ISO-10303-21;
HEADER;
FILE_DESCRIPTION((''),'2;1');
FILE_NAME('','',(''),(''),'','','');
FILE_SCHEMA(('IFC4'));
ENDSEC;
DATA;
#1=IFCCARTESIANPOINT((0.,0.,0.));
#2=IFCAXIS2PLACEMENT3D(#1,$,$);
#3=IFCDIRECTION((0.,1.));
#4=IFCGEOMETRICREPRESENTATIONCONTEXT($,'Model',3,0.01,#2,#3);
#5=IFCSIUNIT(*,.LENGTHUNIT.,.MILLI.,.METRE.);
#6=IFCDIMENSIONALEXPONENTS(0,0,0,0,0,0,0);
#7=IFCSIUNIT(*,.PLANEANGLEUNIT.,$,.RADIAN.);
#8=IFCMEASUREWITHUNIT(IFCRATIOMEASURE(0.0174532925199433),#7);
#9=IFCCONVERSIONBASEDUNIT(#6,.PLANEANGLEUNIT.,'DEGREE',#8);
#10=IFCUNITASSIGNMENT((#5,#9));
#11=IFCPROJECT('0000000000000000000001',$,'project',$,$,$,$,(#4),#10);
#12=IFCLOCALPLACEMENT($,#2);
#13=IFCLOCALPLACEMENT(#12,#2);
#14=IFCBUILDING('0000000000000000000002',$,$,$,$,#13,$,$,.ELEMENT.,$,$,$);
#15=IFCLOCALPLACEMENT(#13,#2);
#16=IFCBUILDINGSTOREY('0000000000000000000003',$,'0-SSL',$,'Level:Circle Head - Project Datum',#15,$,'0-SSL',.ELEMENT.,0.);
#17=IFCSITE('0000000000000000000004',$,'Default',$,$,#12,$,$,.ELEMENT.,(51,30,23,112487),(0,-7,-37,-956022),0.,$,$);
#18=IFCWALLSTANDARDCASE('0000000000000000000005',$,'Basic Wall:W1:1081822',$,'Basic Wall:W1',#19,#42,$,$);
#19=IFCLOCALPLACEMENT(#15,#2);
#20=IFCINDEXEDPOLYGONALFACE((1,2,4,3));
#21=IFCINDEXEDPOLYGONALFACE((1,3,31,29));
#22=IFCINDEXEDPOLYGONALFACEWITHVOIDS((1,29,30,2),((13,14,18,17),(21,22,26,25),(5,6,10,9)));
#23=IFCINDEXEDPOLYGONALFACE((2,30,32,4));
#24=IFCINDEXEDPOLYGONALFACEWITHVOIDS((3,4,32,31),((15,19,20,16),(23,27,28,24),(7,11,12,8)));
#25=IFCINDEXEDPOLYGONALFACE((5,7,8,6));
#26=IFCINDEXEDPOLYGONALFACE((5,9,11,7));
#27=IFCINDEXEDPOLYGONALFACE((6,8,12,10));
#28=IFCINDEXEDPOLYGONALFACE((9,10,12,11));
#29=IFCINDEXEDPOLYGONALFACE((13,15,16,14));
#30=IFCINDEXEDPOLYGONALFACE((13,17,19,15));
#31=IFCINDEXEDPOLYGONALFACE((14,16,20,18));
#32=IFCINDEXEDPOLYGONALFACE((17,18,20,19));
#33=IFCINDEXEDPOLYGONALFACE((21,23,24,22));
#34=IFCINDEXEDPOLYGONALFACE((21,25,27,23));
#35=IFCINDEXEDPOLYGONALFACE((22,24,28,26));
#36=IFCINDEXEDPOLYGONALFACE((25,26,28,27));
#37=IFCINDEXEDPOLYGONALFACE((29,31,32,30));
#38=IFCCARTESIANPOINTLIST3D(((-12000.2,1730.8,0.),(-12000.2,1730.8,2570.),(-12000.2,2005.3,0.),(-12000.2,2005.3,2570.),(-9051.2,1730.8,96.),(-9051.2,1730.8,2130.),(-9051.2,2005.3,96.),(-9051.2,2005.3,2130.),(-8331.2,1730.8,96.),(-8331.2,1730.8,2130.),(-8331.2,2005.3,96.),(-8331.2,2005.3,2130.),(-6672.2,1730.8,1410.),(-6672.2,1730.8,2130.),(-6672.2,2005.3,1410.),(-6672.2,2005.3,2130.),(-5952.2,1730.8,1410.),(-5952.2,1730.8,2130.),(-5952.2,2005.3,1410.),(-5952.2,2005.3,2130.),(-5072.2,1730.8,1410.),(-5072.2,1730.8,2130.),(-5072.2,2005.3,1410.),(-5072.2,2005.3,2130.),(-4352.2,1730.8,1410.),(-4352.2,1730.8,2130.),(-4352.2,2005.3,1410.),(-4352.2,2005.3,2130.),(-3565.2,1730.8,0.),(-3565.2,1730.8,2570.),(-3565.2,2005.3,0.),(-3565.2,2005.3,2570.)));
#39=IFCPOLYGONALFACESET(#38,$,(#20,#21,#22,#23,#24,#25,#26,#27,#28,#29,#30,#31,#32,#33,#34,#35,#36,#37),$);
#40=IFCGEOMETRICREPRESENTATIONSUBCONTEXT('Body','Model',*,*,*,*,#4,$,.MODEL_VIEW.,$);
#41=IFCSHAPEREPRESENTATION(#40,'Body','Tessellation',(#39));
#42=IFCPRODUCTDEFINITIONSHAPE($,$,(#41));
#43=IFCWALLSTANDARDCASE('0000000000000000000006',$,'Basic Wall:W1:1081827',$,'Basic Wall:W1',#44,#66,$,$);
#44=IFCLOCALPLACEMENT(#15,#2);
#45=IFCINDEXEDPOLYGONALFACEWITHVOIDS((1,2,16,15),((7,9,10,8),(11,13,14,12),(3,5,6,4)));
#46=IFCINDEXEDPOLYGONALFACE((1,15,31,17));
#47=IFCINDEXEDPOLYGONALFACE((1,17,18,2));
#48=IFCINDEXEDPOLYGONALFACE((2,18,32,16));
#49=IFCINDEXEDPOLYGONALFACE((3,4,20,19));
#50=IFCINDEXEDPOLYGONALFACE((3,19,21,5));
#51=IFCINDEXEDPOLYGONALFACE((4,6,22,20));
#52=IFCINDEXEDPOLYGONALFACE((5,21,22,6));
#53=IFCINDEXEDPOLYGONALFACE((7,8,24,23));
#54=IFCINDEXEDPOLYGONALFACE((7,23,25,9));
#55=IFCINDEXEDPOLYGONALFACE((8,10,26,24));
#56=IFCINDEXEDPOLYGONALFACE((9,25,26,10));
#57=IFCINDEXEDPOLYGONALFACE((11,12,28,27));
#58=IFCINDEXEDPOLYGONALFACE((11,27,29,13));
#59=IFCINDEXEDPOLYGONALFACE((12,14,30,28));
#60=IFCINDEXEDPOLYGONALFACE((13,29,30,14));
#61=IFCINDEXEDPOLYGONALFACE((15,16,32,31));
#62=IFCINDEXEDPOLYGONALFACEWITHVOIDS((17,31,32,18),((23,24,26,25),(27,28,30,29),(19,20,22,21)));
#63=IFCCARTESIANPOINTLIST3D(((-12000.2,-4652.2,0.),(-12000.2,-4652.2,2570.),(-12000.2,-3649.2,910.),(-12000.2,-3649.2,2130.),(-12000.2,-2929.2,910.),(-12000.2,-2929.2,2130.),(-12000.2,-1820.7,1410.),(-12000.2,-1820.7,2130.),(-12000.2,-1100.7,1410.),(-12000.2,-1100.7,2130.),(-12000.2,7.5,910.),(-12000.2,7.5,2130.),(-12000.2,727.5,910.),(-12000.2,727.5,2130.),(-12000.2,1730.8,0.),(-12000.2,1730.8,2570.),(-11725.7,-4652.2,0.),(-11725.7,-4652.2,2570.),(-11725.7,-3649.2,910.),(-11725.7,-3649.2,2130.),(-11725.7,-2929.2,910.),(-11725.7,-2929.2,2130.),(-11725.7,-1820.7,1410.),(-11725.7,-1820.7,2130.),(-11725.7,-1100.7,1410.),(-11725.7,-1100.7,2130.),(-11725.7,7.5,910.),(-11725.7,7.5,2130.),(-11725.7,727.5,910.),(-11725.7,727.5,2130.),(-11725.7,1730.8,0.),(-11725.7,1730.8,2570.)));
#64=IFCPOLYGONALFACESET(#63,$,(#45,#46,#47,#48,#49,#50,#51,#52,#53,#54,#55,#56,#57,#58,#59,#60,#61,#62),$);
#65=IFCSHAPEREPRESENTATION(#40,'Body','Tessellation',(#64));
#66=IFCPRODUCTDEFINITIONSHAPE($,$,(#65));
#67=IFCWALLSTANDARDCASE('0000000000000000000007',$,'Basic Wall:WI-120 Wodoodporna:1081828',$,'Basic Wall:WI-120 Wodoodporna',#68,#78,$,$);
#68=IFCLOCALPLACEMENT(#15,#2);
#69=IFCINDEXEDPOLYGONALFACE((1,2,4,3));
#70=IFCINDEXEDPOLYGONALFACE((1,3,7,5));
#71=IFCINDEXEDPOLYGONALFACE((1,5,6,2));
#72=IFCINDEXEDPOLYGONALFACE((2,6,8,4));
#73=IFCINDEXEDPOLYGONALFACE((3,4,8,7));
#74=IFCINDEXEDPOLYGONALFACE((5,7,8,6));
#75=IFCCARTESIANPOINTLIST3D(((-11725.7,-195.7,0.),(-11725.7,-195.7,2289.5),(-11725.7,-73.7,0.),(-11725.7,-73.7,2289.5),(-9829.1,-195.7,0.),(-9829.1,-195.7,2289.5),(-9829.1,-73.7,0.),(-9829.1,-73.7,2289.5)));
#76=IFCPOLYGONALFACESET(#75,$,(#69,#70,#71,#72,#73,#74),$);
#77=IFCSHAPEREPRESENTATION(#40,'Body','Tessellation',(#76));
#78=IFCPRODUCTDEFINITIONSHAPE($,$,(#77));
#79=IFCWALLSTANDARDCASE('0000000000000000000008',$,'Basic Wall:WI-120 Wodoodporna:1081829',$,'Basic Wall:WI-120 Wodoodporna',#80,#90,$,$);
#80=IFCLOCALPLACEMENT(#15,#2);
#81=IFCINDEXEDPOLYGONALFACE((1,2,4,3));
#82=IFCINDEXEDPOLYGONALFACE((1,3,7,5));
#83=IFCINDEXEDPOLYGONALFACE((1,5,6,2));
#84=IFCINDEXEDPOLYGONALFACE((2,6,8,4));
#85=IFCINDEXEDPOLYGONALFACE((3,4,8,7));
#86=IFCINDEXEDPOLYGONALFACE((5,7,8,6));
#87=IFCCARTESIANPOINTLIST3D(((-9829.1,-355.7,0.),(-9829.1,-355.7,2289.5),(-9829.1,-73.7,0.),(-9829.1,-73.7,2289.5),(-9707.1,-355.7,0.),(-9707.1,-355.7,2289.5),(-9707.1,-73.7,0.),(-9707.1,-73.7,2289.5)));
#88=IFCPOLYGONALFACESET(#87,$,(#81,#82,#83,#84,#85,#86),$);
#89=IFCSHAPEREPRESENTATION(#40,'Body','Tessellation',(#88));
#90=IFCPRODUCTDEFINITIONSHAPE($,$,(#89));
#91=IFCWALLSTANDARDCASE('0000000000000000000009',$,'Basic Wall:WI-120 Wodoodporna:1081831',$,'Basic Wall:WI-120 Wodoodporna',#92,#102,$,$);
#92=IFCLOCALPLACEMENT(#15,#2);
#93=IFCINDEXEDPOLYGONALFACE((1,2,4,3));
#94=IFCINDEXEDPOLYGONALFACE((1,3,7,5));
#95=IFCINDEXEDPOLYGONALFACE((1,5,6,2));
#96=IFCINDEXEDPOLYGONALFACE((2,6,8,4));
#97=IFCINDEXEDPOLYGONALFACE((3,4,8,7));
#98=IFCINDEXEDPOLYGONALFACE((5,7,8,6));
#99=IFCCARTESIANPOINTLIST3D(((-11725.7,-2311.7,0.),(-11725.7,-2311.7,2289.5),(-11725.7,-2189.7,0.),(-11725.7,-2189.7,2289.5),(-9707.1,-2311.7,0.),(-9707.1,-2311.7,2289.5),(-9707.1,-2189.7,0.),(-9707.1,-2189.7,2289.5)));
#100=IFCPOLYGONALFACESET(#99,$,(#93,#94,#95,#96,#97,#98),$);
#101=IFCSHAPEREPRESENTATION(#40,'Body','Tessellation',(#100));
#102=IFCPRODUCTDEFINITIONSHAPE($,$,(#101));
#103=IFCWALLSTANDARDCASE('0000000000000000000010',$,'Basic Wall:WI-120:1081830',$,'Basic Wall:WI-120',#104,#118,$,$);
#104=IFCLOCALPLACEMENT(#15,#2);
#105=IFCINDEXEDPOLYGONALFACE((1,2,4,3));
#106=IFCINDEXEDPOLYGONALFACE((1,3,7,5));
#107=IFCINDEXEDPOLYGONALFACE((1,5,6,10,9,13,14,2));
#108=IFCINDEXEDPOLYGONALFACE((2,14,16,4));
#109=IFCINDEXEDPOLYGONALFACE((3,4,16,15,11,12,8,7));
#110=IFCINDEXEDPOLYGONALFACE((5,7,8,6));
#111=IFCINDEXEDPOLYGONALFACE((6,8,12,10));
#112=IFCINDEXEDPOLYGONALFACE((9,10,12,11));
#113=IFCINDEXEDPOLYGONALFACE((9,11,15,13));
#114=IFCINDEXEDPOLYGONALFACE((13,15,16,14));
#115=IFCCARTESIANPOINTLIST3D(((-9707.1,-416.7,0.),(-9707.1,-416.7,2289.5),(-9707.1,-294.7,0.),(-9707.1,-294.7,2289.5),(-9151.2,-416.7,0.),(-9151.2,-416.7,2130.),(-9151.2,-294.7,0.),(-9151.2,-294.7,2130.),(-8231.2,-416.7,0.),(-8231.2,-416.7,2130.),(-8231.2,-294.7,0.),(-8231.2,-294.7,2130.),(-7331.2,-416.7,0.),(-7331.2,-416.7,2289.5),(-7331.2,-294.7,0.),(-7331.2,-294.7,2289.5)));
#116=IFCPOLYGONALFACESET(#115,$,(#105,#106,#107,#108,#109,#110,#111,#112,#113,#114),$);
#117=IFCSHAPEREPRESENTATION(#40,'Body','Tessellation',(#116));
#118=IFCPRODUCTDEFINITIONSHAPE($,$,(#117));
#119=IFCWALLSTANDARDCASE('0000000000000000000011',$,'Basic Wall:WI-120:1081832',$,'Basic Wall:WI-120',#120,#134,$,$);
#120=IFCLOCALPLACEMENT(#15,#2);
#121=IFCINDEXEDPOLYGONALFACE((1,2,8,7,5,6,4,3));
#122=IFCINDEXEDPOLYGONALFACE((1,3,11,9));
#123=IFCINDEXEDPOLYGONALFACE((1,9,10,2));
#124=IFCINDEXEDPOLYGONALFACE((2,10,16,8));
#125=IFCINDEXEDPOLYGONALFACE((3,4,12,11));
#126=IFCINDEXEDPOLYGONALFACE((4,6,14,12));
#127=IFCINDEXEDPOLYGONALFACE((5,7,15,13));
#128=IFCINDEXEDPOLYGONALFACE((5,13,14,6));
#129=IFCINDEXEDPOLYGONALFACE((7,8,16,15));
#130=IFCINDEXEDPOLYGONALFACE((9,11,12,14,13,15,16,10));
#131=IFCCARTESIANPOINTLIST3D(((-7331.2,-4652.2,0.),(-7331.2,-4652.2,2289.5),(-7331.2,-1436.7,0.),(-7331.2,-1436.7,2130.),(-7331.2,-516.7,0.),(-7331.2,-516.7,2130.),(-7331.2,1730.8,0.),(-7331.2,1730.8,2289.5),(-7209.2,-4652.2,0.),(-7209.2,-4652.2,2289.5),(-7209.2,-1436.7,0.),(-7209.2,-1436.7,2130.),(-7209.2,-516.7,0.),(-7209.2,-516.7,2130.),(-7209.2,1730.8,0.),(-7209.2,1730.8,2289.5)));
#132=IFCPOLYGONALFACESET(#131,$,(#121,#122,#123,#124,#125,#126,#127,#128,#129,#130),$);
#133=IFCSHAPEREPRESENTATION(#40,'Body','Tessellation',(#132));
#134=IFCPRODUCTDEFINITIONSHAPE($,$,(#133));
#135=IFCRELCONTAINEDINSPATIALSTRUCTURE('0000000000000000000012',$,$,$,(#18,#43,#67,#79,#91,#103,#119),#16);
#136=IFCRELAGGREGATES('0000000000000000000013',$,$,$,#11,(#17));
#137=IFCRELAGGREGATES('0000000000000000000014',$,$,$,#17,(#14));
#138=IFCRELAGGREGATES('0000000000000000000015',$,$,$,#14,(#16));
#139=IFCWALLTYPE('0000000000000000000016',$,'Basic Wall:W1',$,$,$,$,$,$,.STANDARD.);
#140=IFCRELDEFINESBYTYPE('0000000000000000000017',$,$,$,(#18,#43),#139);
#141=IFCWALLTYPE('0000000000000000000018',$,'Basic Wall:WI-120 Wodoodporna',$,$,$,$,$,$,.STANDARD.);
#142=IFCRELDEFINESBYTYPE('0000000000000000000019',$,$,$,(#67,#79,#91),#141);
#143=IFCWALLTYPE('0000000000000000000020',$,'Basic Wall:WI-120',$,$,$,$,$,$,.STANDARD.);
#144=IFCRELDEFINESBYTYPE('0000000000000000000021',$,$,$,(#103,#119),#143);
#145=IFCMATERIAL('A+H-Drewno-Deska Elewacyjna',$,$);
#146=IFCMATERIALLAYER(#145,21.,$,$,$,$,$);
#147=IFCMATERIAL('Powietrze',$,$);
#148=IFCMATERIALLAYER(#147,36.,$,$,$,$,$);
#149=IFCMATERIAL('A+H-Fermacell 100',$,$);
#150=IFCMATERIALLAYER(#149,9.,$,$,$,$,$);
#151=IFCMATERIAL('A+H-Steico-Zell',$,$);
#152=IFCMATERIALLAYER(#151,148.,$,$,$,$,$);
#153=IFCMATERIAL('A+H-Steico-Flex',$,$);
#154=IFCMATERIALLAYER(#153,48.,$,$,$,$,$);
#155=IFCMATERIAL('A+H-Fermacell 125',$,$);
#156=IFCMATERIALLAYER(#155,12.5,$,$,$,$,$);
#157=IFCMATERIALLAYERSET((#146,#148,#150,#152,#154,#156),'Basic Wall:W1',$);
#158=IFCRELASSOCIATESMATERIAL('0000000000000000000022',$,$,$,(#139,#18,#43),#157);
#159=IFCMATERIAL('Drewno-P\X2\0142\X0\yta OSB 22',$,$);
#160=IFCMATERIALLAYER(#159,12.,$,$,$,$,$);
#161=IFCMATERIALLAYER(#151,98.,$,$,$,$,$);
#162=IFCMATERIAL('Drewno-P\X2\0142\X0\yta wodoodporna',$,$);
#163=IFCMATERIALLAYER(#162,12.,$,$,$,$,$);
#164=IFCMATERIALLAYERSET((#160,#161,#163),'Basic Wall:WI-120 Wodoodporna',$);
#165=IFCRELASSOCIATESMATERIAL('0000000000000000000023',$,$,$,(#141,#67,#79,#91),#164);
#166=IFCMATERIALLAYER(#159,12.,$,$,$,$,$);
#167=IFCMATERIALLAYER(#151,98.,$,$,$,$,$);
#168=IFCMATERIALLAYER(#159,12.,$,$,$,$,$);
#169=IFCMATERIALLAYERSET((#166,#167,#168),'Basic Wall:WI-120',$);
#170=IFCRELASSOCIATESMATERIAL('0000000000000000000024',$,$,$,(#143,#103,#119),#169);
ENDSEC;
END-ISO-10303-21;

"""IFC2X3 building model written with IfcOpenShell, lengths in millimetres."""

from ifc_helpers import new_model, entity, si_unit, converted_unit, direction, frame, frame_2d, origin, place, context, subcontext, project, spatial, polyline, rectangle, extrude, clip, bounded_halfspace, material, layer, layer_set, layer_usage, type_object, element, save


model = new_model("IFC2X3")

# Units and contexts
model_context = context("Model", 3, precision=0.01, world=origin(), true_north=direction((0.0, 1.0)))
body_context = subcontext(model_context, "Body", "Model", "MODEL_VIEW")
ifc_project = project(units=[si_unit("LENGTHUNIT", "METRE", prefix="MILLI"), converted_unit("PLANEANGLEUNIT", "DEGREE", entity("IfcRatioMeasure", 0.0174532925199433), si_unit("PLANEANGLEUNIT", "RADIAN"), dimensions=[0, 0, 0, 0, 0, 0, 0])], contexts=[model_context])

# Site, building, storey
site_placement = place(None, origin())
site = spatial("IfcSite", under=ifc_project, at=site_placement, Name="Default", CompositionType="ELEMENT", RefLatitude=(51, 30, 23, 112487), RefLongitude=(0, -7, -37, -956022), RefElevation=0.0)
building_placement = place(site_placement, origin())
building = spatial("IfcBuilding", under=site, at=building_placement, CompositionType="ELEMENT")
storey_placement = place(building_placement, origin())
storey = spatial("IfcBuildingStorey", under=building, at=storey_placement, Name="0-SSL", ObjectType="Level:Circle Head - Project Datum", LongName="0-SSL", CompositionType="ELEMENT", Elevation=0.0)

# Walls, openings
ifc_material_1 = material(Name="A+H-Drewno-Deska Elewacyjna")
ifc_layer_1 = layer(ifc_material_1, 21.0)
ifc_material_2 = material(Name="Powietrze")
ifc_layer_2 = layer(ifc_material_2, 36.0)
ifc_material_3 = material(Name="A+H-Fermacell 100")
ifc_layer_3 = layer(ifc_material_3, 9.0)
ifc_material_4 = material(Name="A+H-Steico-Zell")
ifc_layer_4 = layer(ifc_material_4, 148.0)
ifc_material_5 = material(Name="A+H-Steico-Flex")
ifc_layer_5 = layer(ifc_material_5, 48.0)
ifc_material_6 = material(Name="A+H-Fermacell 125")
ifc_layer_6 = layer(ifc_material_6, 12.5)
ifc_layer_set_1 = layer_set([ifc_layer_1, ifc_layer_2, ifc_layer_3, ifc_layer_4, ifc_layer_5, ifc_layer_6], Name="Basic Wall:W1")
ifc_layer_usage_1 = layer_usage(ifc_layer_set_1, "AXIS2", "NEGATIVE", 137.2)
wall_type_1 = type_object("IfcWallType", Name="Basic Wall:W1", PredefinedType="STANDARD", material=ifc_layer_set_1)
wall_1_placement = place(storey_placement, frame((-12000.2, 1868.0, 0.0)))
wall_1 = element("IfcWallStandardCase", 1, at=wall_1_placement, inside=storey, type_object=wall_type_1, material=ifc_layer_usage_1, Name="Basic Wall:W1:1081822", ObjectType="Basic Wall:W1", context=body_context, shape_type="SweptSolid", body=[
    extrude(rectangle(XDim=8435.0, YDim=274.5, at=frame_2d((4217.5, 0.0), x_axis=(-1.0, 0.0))), origin(), (0.0, 0.0, 1.0), 2570.0),
])
opening_1_placement = place(wall_1_placement, frame((2949.0, -137.2, 96.0)))
element("IfcOpeningElement", 2, at=opening_1_placement, cuts=wall_1, ObjectType="Opening", context=body_context, shape_type="SweptSolid", body=[
    extrude(rectangle(XDim=2034.0, YDim=720.0, at=frame_2d((1017.0, 360.0), x_axis=(-1.0, 0.0))), frame((0.0, 0.0, 0.0), z_axis=(0.0, 1.0, 0.0), x_axis=(0.0, 0.0, 1.0)), (0.0, 0.0, 1.0), 274.5),
])
opening_2_placement = place(wall_1_placement, frame((5328.0, -137.2, 1410.0)))
element("IfcOpeningElement", 3, at=opening_2_placement, cuts=wall_1, ObjectType="Opening", context=body_context, shape_type="SweptSolid", body=[
    extrude(rectangle(XDim=720.0, YDim=720.0, at=frame_2d((360.0, 360.0), x_axis=(-1.0, 0.0))), frame((0.0, 0.0, 0.0), z_axis=(0.0, 1.0, 0.0), x_axis=(0.0, 0.0, 1.0)), (0.0, 0.0, 1.0), 274.5),
])
opening_3_placement = place(wall_1_placement, frame((6928.0, -137.2, 1410.0)))
element("IfcOpeningElement", 4, at=opening_3_placement, cuts=wall_1, ObjectType="Opening", context=body_context, shape_type="SweptSolid", body=[
    extrude(rectangle(XDim=720.0, YDim=720.0, at=frame_2d((360.0, 360.0), x_axis=(-1.0, 0.0))), frame((0.0, 0.0, 0.0), z_axis=(0.0, 1.0, 0.0), x_axis=(0.0, 0.0, 1.0)), (0.0, 0.0, 1.0), 274.5),
])
ifc_layer_usage_2 = layer_usage(ifc_layer_set_1, "AXIS2", "NEGATIVE", 137.2)
wall_2_placement = place(storey_placement, frame((-11862.9, -4652.2, 0.0), z_axis=(0.0, 0.0, 1.0), x_axis=(0.0, 1.0, 0.0)))
wall_2 = element("IfcWallStandardCase", 5, at=wall_2_placement, inside=storey, type_object=wall_type_1, material=ifc_layer_usage_2, Name="Basic Wall:W1:1081827", ObjectType="Basic Wall:W1", context=body_context, shape_type="SweptSolid", body=[
    extrude(rectangle(XDim=6383.0, YDim=274.5, at=frame_2d((3191.5, 0.0), x_axis=(-1.0, 0.0))), origin(), (0.0, 0.0, 1.0), 2570.0),
])
opening_4_placement = place(wall_2_placement, frame((4659.7, -137.3, 910.0)))
element("IfcOpeningElement", 6, at=opening_4_placement, cuts=wall_2, ObjectType="Opening", context=body_context, shape_type="SweptSolid", body=[
    extrude(rectangle(XDim=1220.0, YDim=720.0, at=frame_2d((610.0, 360.0), x_axis=(-1.0, 0.0))), frame((0.0, 0.0, 0.0), z_axis=(0.0, 1.0, 0.0), x_axis=(0.0, 0.0, 1.0)), (0.0, 0.0, 1.0), 274.5),
])
opening_5_placement = place(wall_2_placement, frame((1003.0, -137.3, 910.0)))
element("IfcOpeningElement", 7, at=opening_5_placement, cuts=wall_2, ObjectType="Opening", context=body_context, shape_type="SweptSolid", body=[
    extrude(rectangle(XDim=1220.0, YDim=720.0, at=frame_2d((610.0, 360.0), x_axis=(-1.0, 0.0))), frame((0.0, 0.0, 0.0), z_axis=(0.0, 1.0, 0.0), x_axis=(0.0, 0.0, 1.0)), (0.0, 0.0, 1.0), 274.5),
])
opening_6_placement = place(wall_2_placement, frame((2831.5, -137.3, 1410.0)))
element("IfcOpeningElement", 8, at=opening_6_placement, cuts=wall_2, ObjectType="Opening", context=body_context, shape_type="SweptSolid", body=[
    extrude(rectangle(XDim=720.0, YDim=720.0, at=frame_2d((360.0, 360.0), x_axis=(-1.0, 0.0))), frame((0.0, 0.0, 0.0), z_axis=(0.0, 1.0, 0.0), x_axis=(0.0, 0.0, 1.0)), (0.0, 0.0, 1.0), 274.5),
])

# Walls
ifc_material_7 = material(Name="Drewno-Płyta OSB 22")
ifc_layer_7 = layer(ifc_material_7, 12.0)
ifc_layer_8 = layer(ifc_material_4, 98.0)
ifc_material_8 = material(Name="Drewno-Płyta wodoodporna")
ifc_layer_9 = layer(ifc_material_8, 12.0)
ifc_layer_set_2 = layer_set([ifc_layer_7, ifc_layer_8, ifc_layer_9], Name="Basic Wall:WI-120 Wodoodporna")
ifc_layer_usage_3 = layer_usage(ifc_layer_set_2, "AXIS2", "NEGATIVE", 61.0)
wall_type_2 = type_object("IfcWallType", Name="Basic Wall:WI-120 Wodoodporna", PredefinedType="STANDARD", material=ifc_layer_set_2)
wall_3_placement = place(storey_placement, frame((-11725.7, -134.7, 0.0)))
element("IfcWallStandardCase", 9, at=wall_3_placement, inside=storey, type_object=wall_type_2, material=ifc_layer_usage_3, Name="Basic Wall:WI-120 Wodoodporna:1081828", ObjectType="Basic Wall:WI-120 Wodoodporna", context=body_context, shape_type="Clipping", body=[
    clip(extrude(rectangle(XDim=1896.6, YDim=122.0, at=frame_2d((948.3, 0.0), x_axis=(-1.0, 0.0))), origin(), (0.0, 0.0, 1.0), 2289.5), bounded_halfspace(frame((0.0, -61.0, 2289.5), z_axis=(0.0, 0.0, -1.0), x_axis=(0.0, -1.0, 0.0)), True, frame((0.0, -61.0, 2289.5)), polyline([(0.0, 0.0), (1896.6, 0.0), (1896.6, 122.0), (0.0, 122.0), (0.0, 0.0)]))),
])
ifc_layer_usage_4 = layer_usage(ifc_layer_set_2, "AXIS2", "NEGATIVE", 61.0)
wall_4_placement = place(storey_placement, frame((-9768.1, -73.7, 0.0), z_axis=(0.0, 0.0, 1.0), x_axis=(0.0, -1.0, 0.0)))
element("IfcWallStandardCase", 10, at=wall_4_placement, inside=storey, type_object=wall_type_2, material=ifc_layer_usage_4, Name="Basic Wall:WI-120 Wodoodporna:1081829", ObjectType="Basic Wall:WI-120 Wodoodporna", context=body_context, shape_type="Clipping", body=[
    clip(extrude(rectangle(XDim=282.0, YDim=122.0, at=frame_2d((141.0, 0.0), x_axis=(-1.0, 0.0))), origin(), (0.0, 0.0, 1.0), 2289.5), bounded_halfspace(frame((0.0, -61.0, 2289.5), z_axis=(0.0, 0.0, -1.0), x_axis=(1.0, 0.0, 0.0)), True, frame((0.0, -61.0, 2289.5)), polyline([(0.0, 0.0), (122.0, 0.0), (282.0, 0.0), (282.0, 122.0), (221.0, 122.0), (0.0, 122.0), (0.0, 0.0)]))),
])
ifc_layer_usage_5 = layer_usage(ifc_layer_set_2, "AXIS2", "POSITIVE", -61.0)
wall_5_placement = place(storey_placement, frame((-11725.7, -2250.7, 0.0)))
element("IfcWallStandardCase", 11, at=wall_5_placement, inside=storey, type_object=wall_type_2, material=ifc_layer_usage_5, Name="Basic Wall:WI-120 Wodoodporna:1081831", ObjectType="Basic Wall:WI-120 Wodoodporna", context=body_context, shape_type="Clipping", body=[
    clip(extrude(rectangle(XDim=2018.6, YDim=122.0, at=frame_2d((1009.3, 0.0), x_axis=(-1.0, 0.0))), origin(), (0.0, 0.0, 1.0), 2289.5), bounded_halfspace(frame((0.0, -61.0, 2289.5), z_axis=(0.0, 0.0, -1.0), x_axis=(0.0, -1.0, 0.0)), True, frame((0.0, -61.0, 2289.5)), polyline([(0.0, 0.0), (2018.6, 0.0), (2018.6, 122.0), (1339.5, 122.0), (0.0, 122.0), (0.0, 0.0)]))),
])

# Walls, openings
ifc_layer_10 = layer(ifc_material_7, 12.0)
ifc_layer_11 = layer(ifc_material_4, 98.0)
ifc_layer_12 = layer(ifc_material_7, 12.0)
ifc_layer_set_3 = layer_set([ifc_layer_10, ifc_layer_11, ifc_layer_12], Name="Basic Wall:WI-120")
ifc_layer_usage_6 = layer_usage(ifc_layer_set_3, "AXIS2", "NEGATIVE", 61.0)
wall_type_3 = type_object("IfcWallType", Name="Basic Wall:WI-120", PredefinedType="STANDARD", material=ifc_layer_set_3)
wall_6_placement = place(storey_placement, frame((-9707.1, -355.7, 0.0)))
wall_6 = element("IfcWallStandardCase", 12, at=wall_6_placement, inside=storey, type_object=wall_type_3, material=ifc_layer_usage_6, Name="Basic Wall:WI-120:1081830", ObjectType="Basic Wall:WI-120", context=body_context, shape_type="Clipping", body=[
    clip(extrude(rectangle(XDim=2375.9, YDim=122.0, at=frame_2d((1188.0, 0.0), x_axis=(-1.0, 0.0))), origin(), (0.0, 0.0, 1.0), 2289.5), bounded_halfspace(frame((0.0, -61.0, 2289.5), z_axis=(0.0, 0.0, -1.0), x_axis=(0.0, -1.0, 0.0)), True, frame((0.0, -61.0, 2289.5)), polyline([(0.0, 0.0), (2375.9, 0.0), (2375.9, 122.0), (0.0, 122.0), (0.0, 61.0), (0.0, 0.0)]))),
])
opening_7_placement = place(wall_6_placement, frame((555.9, -61.0, 0.0)))
element("IfcOpeningElement", 13, at=opening_7_placement, cuts=wall_6, ObjectType="Opening", context=body_context, shape_type="SweptSolid", body=[
    extrude(rectangle(XDim=2130.0, YDim=920.0, at=frame_2d((1065.0, 460.0), x_axis=(1.0, 0.0))), frame((0.0, 0.0, 0.0), z_axis=(0.0, 1.0, 0.0), x_axis=(0.0, 0.0, 1.0)), (0.0, 0.0, 1.0), 122.0),
])
ifc_layer_usage_7 = layer_usage(ifc_layer_set_3, "AXIS2", "NEGATIVE", 61.0)
wall_7_placement = place(storey_placement, frame((-7270.2, -4652.2, 0.0), z_axis=(0.0, 0.0, 1.0), x_axis=(0.0, 1.0, 0.0)))
wall_7 = element("IfcWallStandardCase", 14, at=wall_7_placement, inside=storey, type_object=wall_type_3, material=ifc_layer_usage_7, Name="Basic Wall:WI-120:1081832", ObjectType="Basic Wall:WI-120", context=body_context, shape_type="Clipping", body=[
    clip(extrude(rectangle(XDim=6383.0, YDim=122.0, at=frame_2d((3191.5, 0.0), x_axis=(-1.0, 0.0))), origin(), (0.0, 0.0, 1.0), 2289.5), bounded_halfspace(frame((4357.5, -61.0, 2289.5), z_axis=(0.0, 0.0, -1.0), x_axis=(-1.0, 0.0, 0.0)), True, frame((4357.5, -61.0, 2289.5)), polyline([(0.0, 0.0), (2025.5, 0.0), (2025.5, 122.0), (0.0, 122.0), (0.0, 0.0)]))),
])
opening_8_placement = place(wall_7_placement, frame((3215.5, -61.0, 0.0)))
element("IfcOpeningElement", 15, at=opening_8_placement, cuts=wall_7, ObjectType="Opening", context=body_context, shape_type="SweptSolid", body=[
    extrude(rectangle(XDim=2130.0, YDim=920.0, at=frame_2d((1065.0, 460.0), x_axis=(1.0, 0.0))), frame((0.0, 0.0, 0.0), z_axis=(0.0, 1.0, 0.0), x_axis=(0.0, 0.0, 1.0)), (0.0, 0.0, 1.0), 122.0),
])

save(model, "model.ifc")
